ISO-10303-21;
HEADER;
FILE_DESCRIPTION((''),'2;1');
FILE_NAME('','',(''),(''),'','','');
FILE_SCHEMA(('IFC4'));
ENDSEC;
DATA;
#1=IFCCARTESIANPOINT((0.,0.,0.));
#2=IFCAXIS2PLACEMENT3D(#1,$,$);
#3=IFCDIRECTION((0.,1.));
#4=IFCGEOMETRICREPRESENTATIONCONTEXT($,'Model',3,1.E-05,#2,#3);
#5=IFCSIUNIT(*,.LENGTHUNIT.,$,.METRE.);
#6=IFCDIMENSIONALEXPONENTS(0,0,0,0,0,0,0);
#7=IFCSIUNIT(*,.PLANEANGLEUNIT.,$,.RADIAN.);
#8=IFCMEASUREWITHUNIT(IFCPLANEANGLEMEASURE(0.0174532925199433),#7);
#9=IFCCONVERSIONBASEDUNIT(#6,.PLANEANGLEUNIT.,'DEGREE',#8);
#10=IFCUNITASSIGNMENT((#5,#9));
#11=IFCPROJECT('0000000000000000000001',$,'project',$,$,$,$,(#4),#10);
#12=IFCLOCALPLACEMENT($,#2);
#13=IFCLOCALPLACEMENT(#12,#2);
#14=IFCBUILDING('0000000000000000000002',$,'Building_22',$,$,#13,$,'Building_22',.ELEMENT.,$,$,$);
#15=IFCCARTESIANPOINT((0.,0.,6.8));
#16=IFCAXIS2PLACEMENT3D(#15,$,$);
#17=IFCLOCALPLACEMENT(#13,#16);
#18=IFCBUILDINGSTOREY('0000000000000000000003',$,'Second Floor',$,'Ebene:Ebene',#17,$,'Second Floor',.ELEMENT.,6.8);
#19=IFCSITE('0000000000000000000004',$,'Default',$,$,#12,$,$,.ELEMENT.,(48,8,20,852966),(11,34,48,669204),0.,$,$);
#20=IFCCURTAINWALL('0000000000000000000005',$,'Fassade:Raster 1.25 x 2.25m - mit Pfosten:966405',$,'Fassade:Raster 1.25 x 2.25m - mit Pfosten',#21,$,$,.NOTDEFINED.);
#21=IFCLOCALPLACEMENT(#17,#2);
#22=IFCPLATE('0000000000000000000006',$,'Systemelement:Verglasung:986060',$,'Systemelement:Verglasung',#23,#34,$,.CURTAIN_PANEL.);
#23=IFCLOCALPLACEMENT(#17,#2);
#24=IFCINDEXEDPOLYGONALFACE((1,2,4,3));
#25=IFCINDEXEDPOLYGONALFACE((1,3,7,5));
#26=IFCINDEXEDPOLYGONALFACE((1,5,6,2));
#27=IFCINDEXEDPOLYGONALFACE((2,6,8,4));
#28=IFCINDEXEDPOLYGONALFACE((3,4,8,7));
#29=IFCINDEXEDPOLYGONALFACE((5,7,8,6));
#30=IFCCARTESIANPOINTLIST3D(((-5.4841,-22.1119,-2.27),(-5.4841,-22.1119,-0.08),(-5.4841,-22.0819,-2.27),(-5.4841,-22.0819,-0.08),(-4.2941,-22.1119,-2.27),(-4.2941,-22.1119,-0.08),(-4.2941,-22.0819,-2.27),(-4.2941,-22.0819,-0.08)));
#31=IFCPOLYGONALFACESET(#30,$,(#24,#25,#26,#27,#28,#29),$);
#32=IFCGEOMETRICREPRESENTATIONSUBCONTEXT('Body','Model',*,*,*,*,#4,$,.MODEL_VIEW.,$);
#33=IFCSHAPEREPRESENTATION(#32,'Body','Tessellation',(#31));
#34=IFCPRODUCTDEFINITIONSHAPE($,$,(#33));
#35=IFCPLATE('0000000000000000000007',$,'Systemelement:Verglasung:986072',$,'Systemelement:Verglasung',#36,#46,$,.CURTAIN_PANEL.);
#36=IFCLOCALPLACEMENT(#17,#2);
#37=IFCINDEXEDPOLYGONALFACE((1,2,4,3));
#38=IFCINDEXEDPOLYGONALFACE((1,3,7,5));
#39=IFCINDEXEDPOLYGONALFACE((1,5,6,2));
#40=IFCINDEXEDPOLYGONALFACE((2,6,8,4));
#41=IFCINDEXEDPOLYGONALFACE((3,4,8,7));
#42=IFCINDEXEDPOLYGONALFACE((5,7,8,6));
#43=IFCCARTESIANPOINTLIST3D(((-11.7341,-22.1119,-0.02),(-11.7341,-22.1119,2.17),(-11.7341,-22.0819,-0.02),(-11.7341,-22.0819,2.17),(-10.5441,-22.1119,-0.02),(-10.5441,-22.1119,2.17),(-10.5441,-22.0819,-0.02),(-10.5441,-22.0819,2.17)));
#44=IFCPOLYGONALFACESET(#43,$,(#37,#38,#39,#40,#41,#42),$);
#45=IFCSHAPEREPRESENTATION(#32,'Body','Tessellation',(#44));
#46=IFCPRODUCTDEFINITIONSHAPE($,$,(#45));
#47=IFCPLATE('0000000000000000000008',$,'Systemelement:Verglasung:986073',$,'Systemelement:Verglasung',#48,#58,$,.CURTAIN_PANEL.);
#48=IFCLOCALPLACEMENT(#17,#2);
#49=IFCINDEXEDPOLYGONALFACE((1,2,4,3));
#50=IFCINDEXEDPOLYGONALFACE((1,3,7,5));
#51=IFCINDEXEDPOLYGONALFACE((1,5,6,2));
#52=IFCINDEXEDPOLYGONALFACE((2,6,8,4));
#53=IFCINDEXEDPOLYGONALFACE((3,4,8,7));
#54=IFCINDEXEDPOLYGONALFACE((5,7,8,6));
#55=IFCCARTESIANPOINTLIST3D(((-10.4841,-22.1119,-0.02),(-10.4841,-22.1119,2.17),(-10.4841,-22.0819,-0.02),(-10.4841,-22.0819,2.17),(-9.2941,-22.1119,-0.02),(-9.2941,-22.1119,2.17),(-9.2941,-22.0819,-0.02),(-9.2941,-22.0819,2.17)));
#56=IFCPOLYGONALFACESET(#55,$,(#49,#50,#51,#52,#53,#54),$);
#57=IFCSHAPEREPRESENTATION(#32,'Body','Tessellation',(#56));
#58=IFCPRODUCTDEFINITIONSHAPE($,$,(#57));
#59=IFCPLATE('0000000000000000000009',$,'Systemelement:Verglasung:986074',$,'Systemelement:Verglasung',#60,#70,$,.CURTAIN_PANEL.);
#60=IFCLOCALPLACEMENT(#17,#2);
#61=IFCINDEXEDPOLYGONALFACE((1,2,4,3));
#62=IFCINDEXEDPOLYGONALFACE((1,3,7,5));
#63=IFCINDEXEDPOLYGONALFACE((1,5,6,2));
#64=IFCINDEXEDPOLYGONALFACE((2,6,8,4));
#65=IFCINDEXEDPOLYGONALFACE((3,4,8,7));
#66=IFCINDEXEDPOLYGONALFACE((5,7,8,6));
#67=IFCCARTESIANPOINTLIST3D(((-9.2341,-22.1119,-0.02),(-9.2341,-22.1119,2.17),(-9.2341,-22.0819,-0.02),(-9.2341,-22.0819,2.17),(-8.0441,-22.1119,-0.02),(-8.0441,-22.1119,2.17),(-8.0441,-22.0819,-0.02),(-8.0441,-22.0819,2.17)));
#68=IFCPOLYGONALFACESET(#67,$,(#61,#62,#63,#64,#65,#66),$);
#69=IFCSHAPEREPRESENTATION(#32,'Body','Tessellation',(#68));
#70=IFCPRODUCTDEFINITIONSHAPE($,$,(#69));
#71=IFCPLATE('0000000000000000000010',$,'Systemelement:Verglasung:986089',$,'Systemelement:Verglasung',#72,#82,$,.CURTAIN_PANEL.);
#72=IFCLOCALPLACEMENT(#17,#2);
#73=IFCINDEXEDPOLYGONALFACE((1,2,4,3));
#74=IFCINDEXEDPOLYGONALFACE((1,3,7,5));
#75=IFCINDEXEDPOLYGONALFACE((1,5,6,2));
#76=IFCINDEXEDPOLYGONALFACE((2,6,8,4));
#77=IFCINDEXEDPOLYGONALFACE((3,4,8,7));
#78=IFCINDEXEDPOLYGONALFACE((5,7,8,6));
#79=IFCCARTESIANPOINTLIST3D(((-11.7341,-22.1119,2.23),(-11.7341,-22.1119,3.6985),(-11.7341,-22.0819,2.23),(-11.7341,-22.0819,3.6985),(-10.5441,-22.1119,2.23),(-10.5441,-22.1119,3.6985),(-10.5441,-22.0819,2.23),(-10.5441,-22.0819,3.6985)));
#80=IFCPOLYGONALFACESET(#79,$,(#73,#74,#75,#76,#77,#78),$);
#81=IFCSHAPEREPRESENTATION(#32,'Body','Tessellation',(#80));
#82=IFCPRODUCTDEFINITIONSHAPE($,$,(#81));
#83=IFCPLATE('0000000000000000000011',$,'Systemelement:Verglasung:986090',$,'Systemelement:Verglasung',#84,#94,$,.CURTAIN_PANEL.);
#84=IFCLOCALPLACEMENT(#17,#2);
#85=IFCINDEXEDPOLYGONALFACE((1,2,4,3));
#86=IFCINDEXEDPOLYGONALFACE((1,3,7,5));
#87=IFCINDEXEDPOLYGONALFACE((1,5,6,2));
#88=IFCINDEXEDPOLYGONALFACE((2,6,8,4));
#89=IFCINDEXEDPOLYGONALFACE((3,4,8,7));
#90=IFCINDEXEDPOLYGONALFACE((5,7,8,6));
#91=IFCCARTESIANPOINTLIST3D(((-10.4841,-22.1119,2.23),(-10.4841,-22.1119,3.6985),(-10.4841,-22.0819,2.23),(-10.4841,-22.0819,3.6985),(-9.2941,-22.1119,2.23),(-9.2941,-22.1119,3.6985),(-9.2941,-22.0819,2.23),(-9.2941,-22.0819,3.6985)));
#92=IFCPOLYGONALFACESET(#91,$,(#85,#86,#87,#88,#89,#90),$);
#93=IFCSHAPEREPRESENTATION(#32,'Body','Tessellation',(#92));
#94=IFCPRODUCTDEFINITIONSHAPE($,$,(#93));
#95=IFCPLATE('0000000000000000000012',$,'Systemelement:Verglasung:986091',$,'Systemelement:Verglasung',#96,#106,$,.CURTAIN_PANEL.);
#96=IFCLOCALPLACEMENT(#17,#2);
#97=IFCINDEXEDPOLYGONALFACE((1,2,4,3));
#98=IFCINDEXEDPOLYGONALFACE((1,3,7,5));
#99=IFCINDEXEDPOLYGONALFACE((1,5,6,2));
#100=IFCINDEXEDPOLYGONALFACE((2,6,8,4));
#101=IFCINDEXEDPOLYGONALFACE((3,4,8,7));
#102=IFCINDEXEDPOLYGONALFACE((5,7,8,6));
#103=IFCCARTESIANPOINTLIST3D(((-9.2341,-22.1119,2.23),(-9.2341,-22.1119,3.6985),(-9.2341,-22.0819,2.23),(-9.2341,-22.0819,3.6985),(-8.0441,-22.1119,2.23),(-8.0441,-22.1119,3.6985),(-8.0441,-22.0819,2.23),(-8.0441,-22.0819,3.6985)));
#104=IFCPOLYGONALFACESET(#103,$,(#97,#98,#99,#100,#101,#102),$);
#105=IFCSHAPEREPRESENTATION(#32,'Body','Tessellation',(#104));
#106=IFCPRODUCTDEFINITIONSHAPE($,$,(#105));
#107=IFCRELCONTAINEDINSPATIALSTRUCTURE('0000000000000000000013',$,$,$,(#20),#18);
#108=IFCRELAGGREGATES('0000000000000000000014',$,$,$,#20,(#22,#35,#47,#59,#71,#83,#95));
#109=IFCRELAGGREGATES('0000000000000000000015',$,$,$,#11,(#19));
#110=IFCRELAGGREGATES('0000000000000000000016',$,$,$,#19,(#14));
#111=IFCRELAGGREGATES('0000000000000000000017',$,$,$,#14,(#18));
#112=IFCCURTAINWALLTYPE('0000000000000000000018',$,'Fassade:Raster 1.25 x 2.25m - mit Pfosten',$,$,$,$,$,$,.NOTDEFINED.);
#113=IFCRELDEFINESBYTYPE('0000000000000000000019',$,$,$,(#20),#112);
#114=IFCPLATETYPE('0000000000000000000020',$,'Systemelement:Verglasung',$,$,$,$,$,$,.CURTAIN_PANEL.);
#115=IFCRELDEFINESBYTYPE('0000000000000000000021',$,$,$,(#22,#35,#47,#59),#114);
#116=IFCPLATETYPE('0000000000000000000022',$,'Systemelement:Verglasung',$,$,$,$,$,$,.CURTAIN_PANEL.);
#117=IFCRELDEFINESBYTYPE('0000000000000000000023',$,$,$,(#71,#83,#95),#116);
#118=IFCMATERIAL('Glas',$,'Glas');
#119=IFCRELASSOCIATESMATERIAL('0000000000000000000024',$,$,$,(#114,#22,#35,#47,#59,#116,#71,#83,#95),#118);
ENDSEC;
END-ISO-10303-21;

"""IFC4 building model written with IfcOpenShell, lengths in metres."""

from ifc_helpers import new_model, entity, si_unit, converted_unit, direction, frame, origin, place, context, subcontext, project, spatial, indexed_curve, outline, extrude, source, transform, mapped, material, type_object, type_shapes, element, aggregate, save


model = new_model("IFC4")

# Units and contexts
model_context = context("Model", 3, precision=1e-05, world=origin(), true_north=direction((0.0, 1.0)))
body_context = subcontext(model_context, "Body", "Model", "MODEL_VIEW")
ifc_project = project(units=[si_unit("LENGTHUNIT", "METRE"), converted_unit("PLANEANGLEUNIT", "DEGREE", entity("IfcPlaneAngleMeasure", 0.0174532925199433), si_unit("PLANEANGLEUNIT", "RADIAN"), dimensions=[0, 0, 0, 0, 0, 0, 0])], contexts=[model_context])

# Site, building, storey
site_placement = place(None, origin())
site = spatial("IfcSite", under=ifc_project, at=site_placement, Name="Default", CompositionType="ELEMENT", RefLatitude=(48, 8, 20, 852966), RefLongitude=(11, 34, 48, 669204), RefElevation=0.0)
building_placement = place(site_placement, origin())
building = spatial("IfcBuilding", under=site, at=building_placement, Name="Building_22", LongName="Building_22", CompositionType="ELEMENT")
storey_placement = place(building_placement, frame((0.0, 0.0, 6.8)))
storey = spatial("IfcBuildingStorey", under=building, at=storey_placement, Name="Second Floor", ObjectType="Ebene:Ebene", LongName="Second Floor", CompositionType="ELEMENT", Elevation=6.8)

# Curtain wall, plates
curtain_wall_type = type_object("IfcCurtainWallType", Name="Fassade:Raster 1.25 x 2.25m - mit Pfosten", PredefinedType="NOTDEFINED")
curtain_wall_placement = place(storey_placement, frame((0.0, 0.0, -6.8)))
curtain_wall = element("IfcCurtainWall", 1, at=curtain_wall_placement, inside=storey, type_object=curtain_wall_type, Name="Fassade:Raster 1.25 x 2.25m - mit Pfosten:966405", ObjectType="Fassade:Raster 1.25 x 2.25m - mit Pfosten", PredefinedType="NOTDEFINED")
ifc_material_1 = material(Name="Glas", Category="Glas")
plate_type_1 = type_object("IfcPlateType", Name="Systemelement:Verglasung", PredefinedType="CURTAIN_PANEL", material=ifc_material_1)
shared_shape_1 = source(origin(), body_context, "Body", "SweptSolid", [
    extrude(outline(indexed_curve([(-0.015, -0.595), (0.015, -0.595), (0.015, 0.595), (-0.015, 0.595), (-0.015, -0.595)], self_intersect=False)), frame((0.0, 0.0, 0.0), z_axis=(0.0, 0.0, 1.0), x_axis=(0.0, 1.0, 0.0)), (0.0, 0.0, 1.0), 2.19),
])
type_shapes(plate_type_1, [shared_shape_1])
plate_1_placement = place(curtain_wall_placement, frame((-4.8891, -22.0969, 4.53)))
plate_1 = element("IfcPlate", 2, at=plate_1_placement, type_object=plate_type_1, material=ifc_material_1, Name="Systemelement:Verglasung:986060", ObjectType="Systemelement:Verglasung", PredefinedType="CURTAIN_PANEL", context=body_context, shape_type="MappedRepresentation", body=[
    mapped(shared_shape_1, transform((0.0, 0.0, 0.0), scale=1.0)),
])
plate_2_placement = place(curtain_wall_placement, frame((-11.1391, -22.0969, 6.78)))
plate_2 = element("IfcPlate", 3, at=plate_2_placement, type_object=plate_type_1, material=ifc_material_1, Name="Systemelement:Verglasung:986072", ObjectType="Systemelement:Verglasung", PredefinedType="CURTAIN_PANEL", context=body_context, shape_type="MappedRepresentation", body=[
    mapped(shared_shape_1, transform((0.0, 0.0, 0.0), scale=1.0)),
])
plate_3_placement = place(curtain_wall_placement, frame((-9.8891, -22.0969, 6.78)))
plate_3 = element("IfcPlate", 4, at=plate_3_placement, type_object=plate_type_1, material=ifc_material_1, Name="Systemelement:Verglasung:986073", ObjectType="Systemelement:Verglasung", PredefinedType="CURTAIN_PANEL", context=body_context, shape_type="MappedRepresentation", body=[
    mapped(shared_shape_1, transform((0.0, 0.0, 0.0), scale=1.0)),
])
plate_4_placement = place(curtain_wall_placement, frame((-8.6391, -22.0969, 6.78)))
plate_4 = element("IfcPlate", 5, at=plate_4_placement, type_object=plate_type_1, material=ifc_material_1, Name="Systemelement:Verglasung:986074", ObjectType="Systemelement:Verglasung", PredefinedType="CURTAIN_PANEL", context=body_context, shape_type="MappedRepresentation", body=[
    mapped(shared_shape_1, transform((0.0, 0.0, 0.0), scale=1.0)),
])
plate_type_2 = type_object("IfcPlateType", Name="Systemelement:Verglasung", PredefinedType="CURTAIN_PANEL", material=ifc_material_1)
shared_shape_2 = source(origin(), body_context, "Body", "SweptSolid", [
    extrude(outline(indexed_curve([(-0.015, -0.595), (0.015, -0.595), (0.015, 0.595), (-0.015, 0.595), (-0.015, -0.595)], self_intersect=False)), frame((0.0, 0.0, 0.0), z_axis=(0.0, 0.0, 1.0), x_axis=(0.0, 1.0, 0.0)), (0.0, 0.0, 1.0), 1.4685),
])
type_shapes(plate_type_2, [shared_shape_2])
plate_5_placement = place(curtain_wall_placement, frame((-11.1391, -22.0969, 9.03)))
plate_5 = element("IfcPlate", 6, at=plate_5_placement, type_object=plate_type_2, material=ifc_material_1, Name="Systemelement:Verglasung:986089", ObjectType="Systemelement:Verglasung", PredefinedType="CURTAIN_PANEL", context=body_context, shape_type="MappedRepresentation", body=[
    mapped(shared_shape_2, transform((0.0, 0.0, 0.0), scale=1.0)),
])
plate_6_placement = place(curtain_wall_placement, frame((-9.8891, -22.0969, 9.03)))
plate_6 = element("IfcPlate", 7, at=plate_6_placement, type_object=plate_type_2, material=ifc_material_1, Name="Systemelement:Verglasung:986090", ObjectType="Systemelement:Verglasung", PredefinedType="CURTAIN_PANEL", context=body_context, shape_type="MappedRepresentation", body=[
    mapped(shared_shape_2, transform((0.0, 0.0, 0.0), scale=1.0)),
])
plate_7_placement = place(curtain_wall_placement, frame((-8.6391, -22.0969, 9.03)))
plate_7 = element("IfcPlate", 8, at=plate_7_placement, type_object=plate_type_2, material=ifc_material_1, Name="Systemelement:Verglasung:986091", ObjectType="Systemelement:Verglasung", PredefinedType="CURTAIN_PANEL", context=body_context, shape_type="MappedRepresentation", body=[
    mapped(shared_shape_2, transform((0.0, 0.0, 0.0), scale=1.0)),
])
aggregate(curtain_wall, [plate_1, plate_2, plate_3, plate_4, plate_5, plate_6, plate_7])

save(model, "model.ifc")
